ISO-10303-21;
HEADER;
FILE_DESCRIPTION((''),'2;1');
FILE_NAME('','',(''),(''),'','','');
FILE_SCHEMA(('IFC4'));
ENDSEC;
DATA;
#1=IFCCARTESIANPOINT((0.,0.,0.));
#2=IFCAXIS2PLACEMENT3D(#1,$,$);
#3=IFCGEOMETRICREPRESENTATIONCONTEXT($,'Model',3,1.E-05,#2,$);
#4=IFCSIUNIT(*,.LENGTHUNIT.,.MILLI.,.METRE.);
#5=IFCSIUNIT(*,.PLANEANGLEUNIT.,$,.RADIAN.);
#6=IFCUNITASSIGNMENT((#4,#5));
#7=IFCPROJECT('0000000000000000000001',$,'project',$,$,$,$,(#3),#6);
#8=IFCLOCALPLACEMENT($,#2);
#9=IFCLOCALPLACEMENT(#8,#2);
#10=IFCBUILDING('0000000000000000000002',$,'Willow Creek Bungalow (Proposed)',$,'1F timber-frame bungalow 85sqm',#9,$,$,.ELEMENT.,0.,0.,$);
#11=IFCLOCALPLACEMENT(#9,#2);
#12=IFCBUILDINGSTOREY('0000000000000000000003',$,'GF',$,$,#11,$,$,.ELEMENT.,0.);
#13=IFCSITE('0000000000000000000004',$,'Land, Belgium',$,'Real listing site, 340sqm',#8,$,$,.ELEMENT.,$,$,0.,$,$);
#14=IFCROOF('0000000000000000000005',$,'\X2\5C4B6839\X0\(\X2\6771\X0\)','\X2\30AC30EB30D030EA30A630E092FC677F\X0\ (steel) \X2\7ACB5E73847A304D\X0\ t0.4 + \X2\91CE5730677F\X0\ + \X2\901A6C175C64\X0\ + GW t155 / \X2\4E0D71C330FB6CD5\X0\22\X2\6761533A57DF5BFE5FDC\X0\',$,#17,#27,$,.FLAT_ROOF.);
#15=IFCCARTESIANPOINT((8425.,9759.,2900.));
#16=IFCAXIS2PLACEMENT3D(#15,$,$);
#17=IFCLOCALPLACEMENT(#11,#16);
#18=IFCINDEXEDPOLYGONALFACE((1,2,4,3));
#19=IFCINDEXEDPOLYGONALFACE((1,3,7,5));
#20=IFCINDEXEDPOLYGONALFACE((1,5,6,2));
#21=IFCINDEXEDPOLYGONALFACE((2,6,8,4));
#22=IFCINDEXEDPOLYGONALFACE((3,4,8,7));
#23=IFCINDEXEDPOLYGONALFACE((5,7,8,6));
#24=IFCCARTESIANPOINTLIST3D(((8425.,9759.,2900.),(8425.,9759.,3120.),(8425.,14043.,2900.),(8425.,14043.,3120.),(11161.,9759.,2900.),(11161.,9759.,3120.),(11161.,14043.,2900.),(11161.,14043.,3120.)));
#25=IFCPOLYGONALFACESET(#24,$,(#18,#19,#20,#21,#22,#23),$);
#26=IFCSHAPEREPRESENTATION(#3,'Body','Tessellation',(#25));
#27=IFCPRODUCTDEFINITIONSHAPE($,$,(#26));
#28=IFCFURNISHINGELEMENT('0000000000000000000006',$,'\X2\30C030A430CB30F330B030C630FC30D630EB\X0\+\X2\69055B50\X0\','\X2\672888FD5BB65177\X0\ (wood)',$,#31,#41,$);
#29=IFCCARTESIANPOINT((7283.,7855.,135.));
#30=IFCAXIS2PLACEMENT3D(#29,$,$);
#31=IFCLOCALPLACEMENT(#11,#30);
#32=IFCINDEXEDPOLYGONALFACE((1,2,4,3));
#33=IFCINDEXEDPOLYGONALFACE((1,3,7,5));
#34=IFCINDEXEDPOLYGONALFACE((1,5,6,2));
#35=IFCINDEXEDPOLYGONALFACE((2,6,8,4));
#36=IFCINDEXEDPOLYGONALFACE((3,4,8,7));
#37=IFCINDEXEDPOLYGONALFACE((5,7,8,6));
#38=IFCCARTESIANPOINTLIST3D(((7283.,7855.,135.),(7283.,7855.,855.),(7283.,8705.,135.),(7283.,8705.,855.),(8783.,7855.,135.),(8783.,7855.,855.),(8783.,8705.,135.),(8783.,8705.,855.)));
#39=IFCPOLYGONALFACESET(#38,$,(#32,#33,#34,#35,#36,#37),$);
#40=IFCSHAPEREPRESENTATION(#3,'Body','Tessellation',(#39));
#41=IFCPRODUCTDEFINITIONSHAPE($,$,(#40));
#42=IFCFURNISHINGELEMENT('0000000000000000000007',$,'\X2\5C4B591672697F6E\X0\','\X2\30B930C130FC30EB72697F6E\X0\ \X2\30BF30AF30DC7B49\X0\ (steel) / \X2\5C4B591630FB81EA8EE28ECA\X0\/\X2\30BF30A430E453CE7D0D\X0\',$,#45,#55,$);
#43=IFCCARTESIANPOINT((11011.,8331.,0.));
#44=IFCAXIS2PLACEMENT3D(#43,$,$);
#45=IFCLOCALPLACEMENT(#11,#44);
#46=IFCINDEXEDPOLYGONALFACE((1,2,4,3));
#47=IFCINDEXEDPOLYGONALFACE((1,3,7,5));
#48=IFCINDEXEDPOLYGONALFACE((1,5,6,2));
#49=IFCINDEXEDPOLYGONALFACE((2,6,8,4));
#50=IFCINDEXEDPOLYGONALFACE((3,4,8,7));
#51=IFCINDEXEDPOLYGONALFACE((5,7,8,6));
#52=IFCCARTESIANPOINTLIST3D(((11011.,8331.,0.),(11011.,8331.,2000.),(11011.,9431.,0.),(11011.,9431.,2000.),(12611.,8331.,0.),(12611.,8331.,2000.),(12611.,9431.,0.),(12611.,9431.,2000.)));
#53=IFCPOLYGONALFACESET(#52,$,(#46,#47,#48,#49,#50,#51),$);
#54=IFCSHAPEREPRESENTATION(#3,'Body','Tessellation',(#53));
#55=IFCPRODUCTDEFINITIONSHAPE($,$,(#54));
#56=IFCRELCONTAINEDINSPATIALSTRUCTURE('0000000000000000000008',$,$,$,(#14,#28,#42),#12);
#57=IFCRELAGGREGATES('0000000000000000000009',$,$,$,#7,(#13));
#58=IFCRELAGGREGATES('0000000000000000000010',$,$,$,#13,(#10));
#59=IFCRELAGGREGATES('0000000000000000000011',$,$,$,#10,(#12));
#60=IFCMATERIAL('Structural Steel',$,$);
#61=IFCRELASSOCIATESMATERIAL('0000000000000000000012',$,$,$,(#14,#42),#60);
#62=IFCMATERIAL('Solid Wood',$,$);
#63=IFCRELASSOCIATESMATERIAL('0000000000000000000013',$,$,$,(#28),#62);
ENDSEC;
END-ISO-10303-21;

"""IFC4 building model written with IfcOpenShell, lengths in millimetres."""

from ifc_helpers import new_model, si_unit, frame, frame_2d, origin, place, context, project, spatial, rectangle, extrude, material, element, save


model = new_model("IFC4")

# Units and contexts
model_context = context("Model", 3, precision=1e-05, world=origin())
ifc_project = project(units=[si_unit("LENGTHUNIT", "METRE", prefix="MILLI"), si_unit("PLANEANGLEUNIT", "RADIAN")], contexts=[model_context])

# Site, building, storey
site_placement = place(None, origin())
site = spatial("IfcSite", under=ifc_project, at=site_placement, Name="Land, Belgium", ObjectType="Real listing site, 340sqm", CompositionType="ELEMENT", RefElevation=0.0)
building_placement = place(site_placement, origin())
building = spatial("IfcBuilding", under=site, at=building_placement, Name="Willow Creek Bungalow (Proposed)", ObjectType="1F timber-frame bungalow 85sqm", CompositionType="ELEMENT", ElevationOfRefHeight=0.0, ElevationOfTerrain=0.0)
storey_placement = place(building_placement, origin())
storey = spatial("IfcBuildingStorey", under=building, at=storey_placement, Name="GF", CompositionType="ELEMENT", Elevation=0.0)

# Shared definitions
ifc_material_1 = material(Name="Solid Wood")

# Roof
ifc_material_2 = material(Name="Structural Steel")
roof_1_placement = place(storey_placement, frame((8425.0, 9759.0, 2900.0)))
element("IfcRoof", 1, at=roof_1_placement, inside=storey, material=ifc_material_2, Name="屋根(東)", Description="ガルバリウム鋼板 (steel) 立平葺き t0.4 + 野地板 + 通気層 + GW t155 / 不燃・法22条区域対応", PredefinedType="FLAT_ROOF", context=model_context, shape_type="SweptSolid", body=[
    extrude(rectangle(XDim=2736.0, YDim=4284.0, at=frame_2d((1368.0, 2142.0))), frame((8425.0, 9759.0, 2900.0)), (0.0, 0.0, 1.0), 220.0),
])

# Furnishing elements
furnishing_1_placement = place(storey_placement, frame((7283.0, 7855.0, 135.0)))
element("IfcFurnishingElement", 2, at=furnishing_1_placement, inside=storey, material=ifc_material_1, Name="ダイニングテーブル+椅子", Description="木製家具 (wood)", context=model_context, shape_type="SweptSolid", body=[
    extrude(rectangle(XDim=1500.0, YDim=850.0, at=frame_2d((750.0, 425.0))), frame((7283.0, 7855.0, 135.0)), (0.0, 0.0, 1.0), 720.0),
])
furnishing_2_placement = place(storey_placement, frame((11011.0, 8331.0, 0.0)))
element("IfcFurnishingElement", 3, at=furnishing_2_placement, inside=storey, material=ifc_material_2, Name="屋外物置", Description="スチール物置 タクボ等 (steel) / 屋外・自転車/タイヤ収納", context=model_context, shape_type="SweptSolid", body=[
    extrude(rectangle(XDim=1600.0, YDim=1100.0, at=frame_2d((800.0, 550.0))), frame((11011.0, 8331.0, 0.0)), (0.0, 0.0, 1.0), 2000.0),
])

save(model, "model.ifc")
